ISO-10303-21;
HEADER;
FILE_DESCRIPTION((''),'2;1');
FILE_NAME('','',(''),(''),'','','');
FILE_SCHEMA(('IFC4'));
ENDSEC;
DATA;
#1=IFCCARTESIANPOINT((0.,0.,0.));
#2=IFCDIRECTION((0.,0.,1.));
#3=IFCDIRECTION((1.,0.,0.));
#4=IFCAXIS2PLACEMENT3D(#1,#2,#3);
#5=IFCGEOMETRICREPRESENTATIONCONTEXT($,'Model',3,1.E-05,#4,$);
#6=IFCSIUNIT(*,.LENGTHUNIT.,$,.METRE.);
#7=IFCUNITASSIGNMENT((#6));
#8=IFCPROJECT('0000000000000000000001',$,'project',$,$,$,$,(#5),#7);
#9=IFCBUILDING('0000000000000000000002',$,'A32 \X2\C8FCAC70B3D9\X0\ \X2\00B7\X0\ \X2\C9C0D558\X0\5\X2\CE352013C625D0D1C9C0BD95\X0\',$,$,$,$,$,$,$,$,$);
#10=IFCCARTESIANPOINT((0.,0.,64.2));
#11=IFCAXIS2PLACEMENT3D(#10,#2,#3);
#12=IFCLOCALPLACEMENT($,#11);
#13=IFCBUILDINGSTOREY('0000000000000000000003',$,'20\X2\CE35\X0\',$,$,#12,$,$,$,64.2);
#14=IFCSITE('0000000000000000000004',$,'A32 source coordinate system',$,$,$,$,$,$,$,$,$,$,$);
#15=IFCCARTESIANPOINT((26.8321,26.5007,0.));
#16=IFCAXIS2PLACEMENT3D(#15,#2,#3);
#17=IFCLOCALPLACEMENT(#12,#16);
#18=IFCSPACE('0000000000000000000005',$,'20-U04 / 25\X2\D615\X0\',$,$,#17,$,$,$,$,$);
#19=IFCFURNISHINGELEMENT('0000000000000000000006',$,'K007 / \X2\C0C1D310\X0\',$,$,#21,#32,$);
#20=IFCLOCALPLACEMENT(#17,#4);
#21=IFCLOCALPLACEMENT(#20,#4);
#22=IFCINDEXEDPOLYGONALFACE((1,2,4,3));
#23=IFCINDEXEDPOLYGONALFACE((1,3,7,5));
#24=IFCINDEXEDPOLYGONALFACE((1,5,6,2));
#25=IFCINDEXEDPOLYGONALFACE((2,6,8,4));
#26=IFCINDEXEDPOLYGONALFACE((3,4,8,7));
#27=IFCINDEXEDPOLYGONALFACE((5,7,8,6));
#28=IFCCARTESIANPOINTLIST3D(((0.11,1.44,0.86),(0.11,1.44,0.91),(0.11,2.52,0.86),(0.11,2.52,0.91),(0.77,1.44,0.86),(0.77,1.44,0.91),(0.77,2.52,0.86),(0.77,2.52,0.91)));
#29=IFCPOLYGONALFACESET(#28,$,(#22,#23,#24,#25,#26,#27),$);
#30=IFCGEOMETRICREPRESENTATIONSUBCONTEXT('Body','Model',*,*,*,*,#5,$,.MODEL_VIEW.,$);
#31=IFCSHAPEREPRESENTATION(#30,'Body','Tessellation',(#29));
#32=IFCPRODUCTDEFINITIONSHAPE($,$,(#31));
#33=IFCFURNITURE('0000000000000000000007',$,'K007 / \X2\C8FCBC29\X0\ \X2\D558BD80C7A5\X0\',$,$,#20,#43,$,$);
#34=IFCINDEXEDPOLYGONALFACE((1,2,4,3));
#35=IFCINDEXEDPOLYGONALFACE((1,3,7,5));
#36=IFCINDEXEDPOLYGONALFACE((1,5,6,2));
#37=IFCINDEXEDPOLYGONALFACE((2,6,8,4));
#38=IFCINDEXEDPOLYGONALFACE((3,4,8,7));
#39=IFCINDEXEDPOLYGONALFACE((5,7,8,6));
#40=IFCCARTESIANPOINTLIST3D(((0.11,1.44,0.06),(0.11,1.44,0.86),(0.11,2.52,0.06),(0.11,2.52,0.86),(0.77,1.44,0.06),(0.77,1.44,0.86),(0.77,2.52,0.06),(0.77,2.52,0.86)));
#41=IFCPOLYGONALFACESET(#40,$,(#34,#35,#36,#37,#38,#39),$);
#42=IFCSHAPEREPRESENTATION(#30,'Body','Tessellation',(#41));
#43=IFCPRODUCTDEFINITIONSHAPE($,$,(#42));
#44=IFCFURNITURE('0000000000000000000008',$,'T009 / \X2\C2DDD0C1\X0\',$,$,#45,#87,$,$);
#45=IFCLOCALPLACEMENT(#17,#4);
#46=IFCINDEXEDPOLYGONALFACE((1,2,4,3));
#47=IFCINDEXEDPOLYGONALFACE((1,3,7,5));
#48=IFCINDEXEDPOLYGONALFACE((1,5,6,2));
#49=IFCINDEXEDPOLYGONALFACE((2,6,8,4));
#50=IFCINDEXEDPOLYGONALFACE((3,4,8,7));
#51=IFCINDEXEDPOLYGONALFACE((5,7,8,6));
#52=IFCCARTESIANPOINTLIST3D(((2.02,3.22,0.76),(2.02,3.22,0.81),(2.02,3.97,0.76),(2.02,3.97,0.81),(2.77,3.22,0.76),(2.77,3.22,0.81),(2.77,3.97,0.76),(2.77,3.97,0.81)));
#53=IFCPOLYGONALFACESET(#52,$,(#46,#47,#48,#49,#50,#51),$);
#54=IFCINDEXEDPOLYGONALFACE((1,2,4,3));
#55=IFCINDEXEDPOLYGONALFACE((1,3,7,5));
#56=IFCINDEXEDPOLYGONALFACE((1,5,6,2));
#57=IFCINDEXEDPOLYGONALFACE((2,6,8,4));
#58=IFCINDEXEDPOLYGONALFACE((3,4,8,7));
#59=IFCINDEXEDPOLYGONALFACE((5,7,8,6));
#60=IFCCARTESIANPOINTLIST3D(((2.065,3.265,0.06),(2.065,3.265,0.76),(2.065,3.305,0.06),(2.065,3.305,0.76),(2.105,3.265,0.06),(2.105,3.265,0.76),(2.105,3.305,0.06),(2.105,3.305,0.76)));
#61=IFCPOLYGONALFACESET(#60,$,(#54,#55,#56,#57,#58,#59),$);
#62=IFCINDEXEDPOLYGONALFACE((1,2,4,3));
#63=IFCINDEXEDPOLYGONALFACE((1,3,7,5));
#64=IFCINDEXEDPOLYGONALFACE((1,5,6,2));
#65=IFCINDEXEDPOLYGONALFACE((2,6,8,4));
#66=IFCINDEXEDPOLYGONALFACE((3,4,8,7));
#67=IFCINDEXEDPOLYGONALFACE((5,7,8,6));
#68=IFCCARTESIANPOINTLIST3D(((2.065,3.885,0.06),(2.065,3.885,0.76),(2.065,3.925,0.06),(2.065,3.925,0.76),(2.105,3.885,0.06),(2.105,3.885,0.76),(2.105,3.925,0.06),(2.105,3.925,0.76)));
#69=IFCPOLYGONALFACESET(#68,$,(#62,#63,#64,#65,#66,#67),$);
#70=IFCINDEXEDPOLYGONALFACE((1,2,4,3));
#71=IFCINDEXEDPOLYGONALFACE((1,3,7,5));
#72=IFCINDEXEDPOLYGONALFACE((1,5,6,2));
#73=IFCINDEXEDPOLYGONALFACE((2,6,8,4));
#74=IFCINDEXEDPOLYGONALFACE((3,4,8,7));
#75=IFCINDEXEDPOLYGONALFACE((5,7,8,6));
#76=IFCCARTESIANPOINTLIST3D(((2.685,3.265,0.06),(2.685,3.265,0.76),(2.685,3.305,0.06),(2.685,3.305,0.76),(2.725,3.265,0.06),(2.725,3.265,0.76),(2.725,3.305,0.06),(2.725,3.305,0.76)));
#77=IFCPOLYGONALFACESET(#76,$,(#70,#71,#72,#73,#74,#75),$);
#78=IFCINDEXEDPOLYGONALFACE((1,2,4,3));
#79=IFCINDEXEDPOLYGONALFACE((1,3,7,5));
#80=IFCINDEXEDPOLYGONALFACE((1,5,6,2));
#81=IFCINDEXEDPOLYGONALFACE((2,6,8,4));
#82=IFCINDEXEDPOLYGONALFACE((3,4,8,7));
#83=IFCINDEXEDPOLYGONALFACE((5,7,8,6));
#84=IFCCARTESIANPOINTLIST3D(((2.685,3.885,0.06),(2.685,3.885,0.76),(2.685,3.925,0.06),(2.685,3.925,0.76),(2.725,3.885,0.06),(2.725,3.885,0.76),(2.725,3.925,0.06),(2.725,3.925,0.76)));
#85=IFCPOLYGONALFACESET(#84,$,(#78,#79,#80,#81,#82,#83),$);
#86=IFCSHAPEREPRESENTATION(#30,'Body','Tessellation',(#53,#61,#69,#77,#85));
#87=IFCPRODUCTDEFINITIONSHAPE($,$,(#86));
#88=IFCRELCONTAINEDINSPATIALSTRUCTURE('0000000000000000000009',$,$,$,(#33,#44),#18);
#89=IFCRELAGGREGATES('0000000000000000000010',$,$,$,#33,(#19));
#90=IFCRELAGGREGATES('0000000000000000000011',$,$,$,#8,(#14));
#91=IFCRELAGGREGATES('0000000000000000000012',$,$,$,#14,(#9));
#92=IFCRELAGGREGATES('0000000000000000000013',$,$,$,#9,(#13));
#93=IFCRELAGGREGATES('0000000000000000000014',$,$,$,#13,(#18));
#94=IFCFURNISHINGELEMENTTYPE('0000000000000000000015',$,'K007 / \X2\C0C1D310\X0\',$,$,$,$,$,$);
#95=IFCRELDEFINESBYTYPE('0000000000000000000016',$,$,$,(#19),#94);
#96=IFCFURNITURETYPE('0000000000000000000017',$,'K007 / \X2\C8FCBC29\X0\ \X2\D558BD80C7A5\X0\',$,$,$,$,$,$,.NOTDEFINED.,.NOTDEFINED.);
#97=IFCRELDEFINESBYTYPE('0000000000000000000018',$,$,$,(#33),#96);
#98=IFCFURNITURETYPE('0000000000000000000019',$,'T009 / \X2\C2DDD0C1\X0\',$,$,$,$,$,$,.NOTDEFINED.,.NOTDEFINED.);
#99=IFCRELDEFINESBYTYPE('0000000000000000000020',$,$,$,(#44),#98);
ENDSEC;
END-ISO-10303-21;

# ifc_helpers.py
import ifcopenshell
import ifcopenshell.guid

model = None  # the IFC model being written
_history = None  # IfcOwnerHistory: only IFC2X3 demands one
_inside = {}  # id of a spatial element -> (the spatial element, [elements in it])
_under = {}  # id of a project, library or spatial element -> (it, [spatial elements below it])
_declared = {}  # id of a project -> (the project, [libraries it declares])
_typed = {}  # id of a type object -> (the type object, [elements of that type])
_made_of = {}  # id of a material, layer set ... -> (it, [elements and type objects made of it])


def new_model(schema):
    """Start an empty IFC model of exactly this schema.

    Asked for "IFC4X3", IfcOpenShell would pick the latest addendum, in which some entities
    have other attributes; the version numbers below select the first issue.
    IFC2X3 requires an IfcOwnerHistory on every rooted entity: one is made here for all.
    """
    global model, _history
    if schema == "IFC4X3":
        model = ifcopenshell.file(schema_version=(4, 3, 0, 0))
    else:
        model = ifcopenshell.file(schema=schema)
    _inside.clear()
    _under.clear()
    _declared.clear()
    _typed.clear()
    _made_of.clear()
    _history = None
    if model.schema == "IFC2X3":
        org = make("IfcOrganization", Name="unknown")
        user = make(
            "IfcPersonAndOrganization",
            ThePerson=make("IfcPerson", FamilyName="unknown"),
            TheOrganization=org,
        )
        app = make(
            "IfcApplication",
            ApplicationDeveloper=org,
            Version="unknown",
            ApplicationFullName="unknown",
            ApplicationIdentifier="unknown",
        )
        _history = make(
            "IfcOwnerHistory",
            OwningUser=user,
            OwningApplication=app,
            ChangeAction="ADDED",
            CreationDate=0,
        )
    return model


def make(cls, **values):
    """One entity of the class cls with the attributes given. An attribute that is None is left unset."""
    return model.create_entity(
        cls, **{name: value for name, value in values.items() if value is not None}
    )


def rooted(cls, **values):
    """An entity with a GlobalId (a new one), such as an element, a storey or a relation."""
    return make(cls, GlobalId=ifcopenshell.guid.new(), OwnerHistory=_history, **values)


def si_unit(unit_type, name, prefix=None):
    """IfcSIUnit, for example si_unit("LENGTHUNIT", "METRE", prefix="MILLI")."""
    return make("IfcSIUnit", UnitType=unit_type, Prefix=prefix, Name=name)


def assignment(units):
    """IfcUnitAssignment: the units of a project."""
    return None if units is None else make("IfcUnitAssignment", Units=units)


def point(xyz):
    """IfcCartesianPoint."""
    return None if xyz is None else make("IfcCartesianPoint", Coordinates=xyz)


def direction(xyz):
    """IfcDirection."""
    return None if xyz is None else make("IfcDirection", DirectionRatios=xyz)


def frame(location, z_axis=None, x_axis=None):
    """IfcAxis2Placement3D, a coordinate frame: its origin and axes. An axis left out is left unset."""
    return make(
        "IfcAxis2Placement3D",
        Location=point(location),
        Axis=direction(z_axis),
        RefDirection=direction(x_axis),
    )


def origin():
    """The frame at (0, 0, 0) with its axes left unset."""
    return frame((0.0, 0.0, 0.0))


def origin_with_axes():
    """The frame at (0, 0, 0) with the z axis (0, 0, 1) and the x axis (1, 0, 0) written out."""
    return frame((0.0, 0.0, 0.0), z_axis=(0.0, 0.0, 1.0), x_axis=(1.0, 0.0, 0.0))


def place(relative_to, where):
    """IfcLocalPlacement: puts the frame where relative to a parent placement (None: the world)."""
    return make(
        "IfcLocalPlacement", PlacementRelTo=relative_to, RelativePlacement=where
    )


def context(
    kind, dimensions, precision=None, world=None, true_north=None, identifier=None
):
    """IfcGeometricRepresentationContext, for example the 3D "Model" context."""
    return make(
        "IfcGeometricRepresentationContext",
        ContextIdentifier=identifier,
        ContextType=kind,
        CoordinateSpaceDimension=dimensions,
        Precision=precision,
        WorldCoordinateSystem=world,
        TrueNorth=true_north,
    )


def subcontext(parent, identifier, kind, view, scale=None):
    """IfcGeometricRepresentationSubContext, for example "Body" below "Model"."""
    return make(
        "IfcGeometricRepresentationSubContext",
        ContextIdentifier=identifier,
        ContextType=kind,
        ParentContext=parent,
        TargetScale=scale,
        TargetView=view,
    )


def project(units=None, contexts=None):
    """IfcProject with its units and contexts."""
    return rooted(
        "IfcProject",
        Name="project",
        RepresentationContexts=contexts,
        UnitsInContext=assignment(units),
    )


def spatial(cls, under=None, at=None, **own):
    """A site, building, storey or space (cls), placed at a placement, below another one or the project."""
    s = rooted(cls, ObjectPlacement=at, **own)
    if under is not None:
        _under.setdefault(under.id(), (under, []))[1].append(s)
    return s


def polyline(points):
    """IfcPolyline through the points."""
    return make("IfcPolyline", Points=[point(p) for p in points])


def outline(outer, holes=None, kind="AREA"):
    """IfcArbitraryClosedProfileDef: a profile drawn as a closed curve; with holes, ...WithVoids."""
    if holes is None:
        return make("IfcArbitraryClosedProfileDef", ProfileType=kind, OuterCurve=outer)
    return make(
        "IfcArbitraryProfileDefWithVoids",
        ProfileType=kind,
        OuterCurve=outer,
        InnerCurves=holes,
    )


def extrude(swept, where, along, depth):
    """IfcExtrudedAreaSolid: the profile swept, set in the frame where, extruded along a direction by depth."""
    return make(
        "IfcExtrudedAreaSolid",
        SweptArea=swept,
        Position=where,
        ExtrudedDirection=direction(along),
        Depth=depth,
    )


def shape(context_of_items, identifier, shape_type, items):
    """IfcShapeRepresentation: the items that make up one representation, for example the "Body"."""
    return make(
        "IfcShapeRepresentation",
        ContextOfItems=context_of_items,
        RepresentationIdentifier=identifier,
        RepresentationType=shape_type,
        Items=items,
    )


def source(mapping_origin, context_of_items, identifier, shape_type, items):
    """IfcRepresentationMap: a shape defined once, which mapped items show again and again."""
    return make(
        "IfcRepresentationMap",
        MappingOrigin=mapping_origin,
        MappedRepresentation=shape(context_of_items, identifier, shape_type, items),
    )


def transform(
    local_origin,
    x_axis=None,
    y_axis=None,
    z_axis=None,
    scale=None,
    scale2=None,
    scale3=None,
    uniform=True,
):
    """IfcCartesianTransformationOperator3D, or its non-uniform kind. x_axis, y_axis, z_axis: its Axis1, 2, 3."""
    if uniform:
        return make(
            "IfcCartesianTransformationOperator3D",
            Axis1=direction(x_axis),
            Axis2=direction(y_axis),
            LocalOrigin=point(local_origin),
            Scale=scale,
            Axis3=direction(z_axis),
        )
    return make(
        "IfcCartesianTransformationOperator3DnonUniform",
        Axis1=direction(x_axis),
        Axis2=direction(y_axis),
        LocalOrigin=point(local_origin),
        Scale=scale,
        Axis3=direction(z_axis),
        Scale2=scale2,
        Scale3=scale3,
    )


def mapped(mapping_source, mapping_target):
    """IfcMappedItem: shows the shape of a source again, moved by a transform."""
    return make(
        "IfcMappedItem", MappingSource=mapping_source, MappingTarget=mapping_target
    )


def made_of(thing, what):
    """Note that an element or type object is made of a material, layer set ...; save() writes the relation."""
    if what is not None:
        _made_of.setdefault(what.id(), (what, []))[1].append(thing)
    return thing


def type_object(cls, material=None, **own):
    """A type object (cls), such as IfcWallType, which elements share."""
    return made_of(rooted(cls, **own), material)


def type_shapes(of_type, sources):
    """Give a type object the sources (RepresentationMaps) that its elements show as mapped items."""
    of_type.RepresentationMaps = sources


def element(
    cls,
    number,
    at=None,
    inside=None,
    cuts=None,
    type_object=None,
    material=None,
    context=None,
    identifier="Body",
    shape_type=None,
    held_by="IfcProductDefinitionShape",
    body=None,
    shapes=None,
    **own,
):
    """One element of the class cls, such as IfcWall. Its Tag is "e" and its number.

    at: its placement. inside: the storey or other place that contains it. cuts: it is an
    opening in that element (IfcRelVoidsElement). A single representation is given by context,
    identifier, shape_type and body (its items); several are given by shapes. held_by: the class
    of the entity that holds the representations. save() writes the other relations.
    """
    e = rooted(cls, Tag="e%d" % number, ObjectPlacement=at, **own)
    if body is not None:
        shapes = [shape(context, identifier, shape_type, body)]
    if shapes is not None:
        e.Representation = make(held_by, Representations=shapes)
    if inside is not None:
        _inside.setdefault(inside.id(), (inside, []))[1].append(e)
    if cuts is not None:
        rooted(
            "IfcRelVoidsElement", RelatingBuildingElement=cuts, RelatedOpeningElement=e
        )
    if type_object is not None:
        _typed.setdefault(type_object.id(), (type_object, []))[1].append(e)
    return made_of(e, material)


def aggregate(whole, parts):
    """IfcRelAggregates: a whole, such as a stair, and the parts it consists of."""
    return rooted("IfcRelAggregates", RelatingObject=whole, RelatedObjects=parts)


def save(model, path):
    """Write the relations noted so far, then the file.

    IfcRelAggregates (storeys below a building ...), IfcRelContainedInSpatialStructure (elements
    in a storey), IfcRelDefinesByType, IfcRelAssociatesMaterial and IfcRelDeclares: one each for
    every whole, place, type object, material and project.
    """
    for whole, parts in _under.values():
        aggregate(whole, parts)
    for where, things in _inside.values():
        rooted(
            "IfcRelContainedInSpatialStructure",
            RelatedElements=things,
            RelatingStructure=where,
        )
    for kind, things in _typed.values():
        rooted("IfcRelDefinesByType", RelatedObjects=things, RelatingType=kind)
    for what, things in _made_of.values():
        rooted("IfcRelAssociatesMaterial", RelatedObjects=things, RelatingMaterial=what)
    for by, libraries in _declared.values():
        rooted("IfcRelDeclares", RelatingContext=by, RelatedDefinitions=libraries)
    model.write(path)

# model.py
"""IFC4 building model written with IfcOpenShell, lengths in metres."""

from ifc_helpers import new_model, si_unit, frame, origin, origin_with_axes, place, context, subcontext, project, spatial, polyline, outline, extrude, source, transform, mapped, type_object, type_shapes, element, aggregate, save


model = new_model("IFC4")

# Units and contexts
model_context = context("Model", 3, precision=1e-05, world=origin_with_axes())
body_context = subcontext(model_context, "Body", "Model", "MODEL_VIEW")
ifc_project = project(units=[si_unit("LENGTHUNIT", "METRE")], contexts=[model_context])

# Site, building, storey
site = spatial("IfcSite", under=ifc_project, Name="A32 source coordinate system")
building = spatial("IfcBuilding", under=site, Name="A32 주거동 · 지하5층–옥탑지붕")
storey_placement = place(None, frame((0.0, 0.0, 64.2), z_axis=(0.0, 0.0, 1.0), x_axis=(1.0, 0.0, 0.0)))
storey = spatial("IfcBuildingStorey", under=building, at=storey_placement, Name="20층", Elevation=64.2)

# Shared definitions
space_1_placement = place(storey_placement, frame((26.8321, 26.5007, 0.0), z_axis=(0.0, 0.0, 1.0), x_axis=(1.0, 0.0, 0.0)))
space_1 = spatial("IfcSpace", under=storey, at=space_1_placement, Name="20-U04 / 25형")

# Furnishing element
furnishing_element_type_1 = type_object("IfcFurnishingElementType", Name="K007 / 상판")
shared_shape_1 = source(origin(), body_context, "Body", "SweptSolid", [
    extrude(outline(polyline([(0.77, 2.52), (0.77, 1.44), (0.11, 1.44), (0.11, 2.52), (0.77, 2.52)])), frame((0.0, 0.0, 0.86)), (0.0, 0.0, 1.0), 0.05),
])
type_shapes(furnishing_element_type_1, [shared_shape_1])
furniture_1_placement = place(space_1_placement, origin_with_axes())
furnishing_1_placement = place(furniture_1_placement, origin_with_axes())
furnishing_1 = element("IfcFurnishingElement", 1, at=furnishing_1_placement, type_object=furnishing_element_type_1, Name="K007 / 상판", context=body_context, shape_type="MappedRepresentation", body=[
    mapped(shared_shape_1, transform((0.0, 0.0, 0.0), scale=1.0)),
])

# Furniture
furniture_type_1 = type_object("IfcFurnitureType", Name="K007 / 주방 하부장", AssemblyPlace="NOTDEFINED", PredefinedType="NOTDEFINED")
shared_shape_2 = source(origin(), body_context, "Body", "SweptSolid", [
    extrude(outline(polyline([(0.11, 2.52), (0.77, 2.52), (0.77, 1.44), (0.11, 1.44), (0.11, 2.52)])), frame((0.0, 0.0, 0.06)), (0.0, 0.0, 1.0), 0.8),
])
type_shapes(furniture_type_1, [shared_shape_2])
furniture_1 = element("IfcFurniture", 2, at=furniture_1_placement, inside=space_1, type_object=furniture_type_1, Name="K007 / 주방 하부장", context=body_context, shape_type="MappedRepresentation", body=[
    mapped(shared_shape_2, transform((0.0, 0.0, 0.0), scale=1.0)),
])
aggregate(furniture_1, [furnishing_1])
furniture_type_2 = type_object("IfcFurnitureType", Name="T009 / 식탁", AssemblyPlace="NOTDEFINED", PredefinedType="NOTDEFINED")
shared_shape_3 = source(origin(), body_context, "Body", "SweptSolid", [
    extrude(outline(polyline([(2.77, 3.22), (2.02, 3.22), (2.02, 3.97), (2.77, 3.97), (2.77, 3.22)])), frame((0.0, 0.0, 0.76)), (0.0, 0.0, 1.0), 0.05),
    extrude(outline(polyline([(2.065, 3.265), (2.065, 3.305), (2.105, 3.305), (2.105, 3.265), (2.065, 3.265)])), frame((0.0, 0.0, 0.06)), (0.0, 0.0, 1.0), 0.7),
    extrude(outline(polyline([(2.065, 3.885), (2.065, 3.925), (2.105, 3.925), (2.105, 3.885), (2.065, 3.885)])), frame((0.0, 0.0, 0.06)), (0.0, 0.0, 1.0), 0.7),
    extrude(outline(polyline([(2.685, 3.265), (2.685, 3.305), (2.725, 3.305), (2.725, 3.265), (2.685, 3.265)])), frame((0.0, 0.0, 0.06)), (0.0, 0.0, 1.0), 0.7),
    extrude(outline(polyline([(2.685, 3.885), (2.685, 3.925), (2.725, 3.925), (2.725, 3.885), (2.685, 3.885)])), frame((0.0, 0.0, 0.06)), (0.0, 0.0, 1.0), 0.7),
])
type_shapes(furniture_type_2, [shared_shape_3])
furniture_2_placement = place(space_1_placement, origin_with_axes())
element("IfcFurniture", 3, at=furniture_2_placement, inside=space_1, type_object=furniture_type_2, Name="T009 / 식탁", context=body_context, shape_type="MappedRepresentation", body=[
    mapped(shared_shape_3, transform((0.0, 0.0, 0.0), scale=1.0)),
])

save(model, "model.ifc")
